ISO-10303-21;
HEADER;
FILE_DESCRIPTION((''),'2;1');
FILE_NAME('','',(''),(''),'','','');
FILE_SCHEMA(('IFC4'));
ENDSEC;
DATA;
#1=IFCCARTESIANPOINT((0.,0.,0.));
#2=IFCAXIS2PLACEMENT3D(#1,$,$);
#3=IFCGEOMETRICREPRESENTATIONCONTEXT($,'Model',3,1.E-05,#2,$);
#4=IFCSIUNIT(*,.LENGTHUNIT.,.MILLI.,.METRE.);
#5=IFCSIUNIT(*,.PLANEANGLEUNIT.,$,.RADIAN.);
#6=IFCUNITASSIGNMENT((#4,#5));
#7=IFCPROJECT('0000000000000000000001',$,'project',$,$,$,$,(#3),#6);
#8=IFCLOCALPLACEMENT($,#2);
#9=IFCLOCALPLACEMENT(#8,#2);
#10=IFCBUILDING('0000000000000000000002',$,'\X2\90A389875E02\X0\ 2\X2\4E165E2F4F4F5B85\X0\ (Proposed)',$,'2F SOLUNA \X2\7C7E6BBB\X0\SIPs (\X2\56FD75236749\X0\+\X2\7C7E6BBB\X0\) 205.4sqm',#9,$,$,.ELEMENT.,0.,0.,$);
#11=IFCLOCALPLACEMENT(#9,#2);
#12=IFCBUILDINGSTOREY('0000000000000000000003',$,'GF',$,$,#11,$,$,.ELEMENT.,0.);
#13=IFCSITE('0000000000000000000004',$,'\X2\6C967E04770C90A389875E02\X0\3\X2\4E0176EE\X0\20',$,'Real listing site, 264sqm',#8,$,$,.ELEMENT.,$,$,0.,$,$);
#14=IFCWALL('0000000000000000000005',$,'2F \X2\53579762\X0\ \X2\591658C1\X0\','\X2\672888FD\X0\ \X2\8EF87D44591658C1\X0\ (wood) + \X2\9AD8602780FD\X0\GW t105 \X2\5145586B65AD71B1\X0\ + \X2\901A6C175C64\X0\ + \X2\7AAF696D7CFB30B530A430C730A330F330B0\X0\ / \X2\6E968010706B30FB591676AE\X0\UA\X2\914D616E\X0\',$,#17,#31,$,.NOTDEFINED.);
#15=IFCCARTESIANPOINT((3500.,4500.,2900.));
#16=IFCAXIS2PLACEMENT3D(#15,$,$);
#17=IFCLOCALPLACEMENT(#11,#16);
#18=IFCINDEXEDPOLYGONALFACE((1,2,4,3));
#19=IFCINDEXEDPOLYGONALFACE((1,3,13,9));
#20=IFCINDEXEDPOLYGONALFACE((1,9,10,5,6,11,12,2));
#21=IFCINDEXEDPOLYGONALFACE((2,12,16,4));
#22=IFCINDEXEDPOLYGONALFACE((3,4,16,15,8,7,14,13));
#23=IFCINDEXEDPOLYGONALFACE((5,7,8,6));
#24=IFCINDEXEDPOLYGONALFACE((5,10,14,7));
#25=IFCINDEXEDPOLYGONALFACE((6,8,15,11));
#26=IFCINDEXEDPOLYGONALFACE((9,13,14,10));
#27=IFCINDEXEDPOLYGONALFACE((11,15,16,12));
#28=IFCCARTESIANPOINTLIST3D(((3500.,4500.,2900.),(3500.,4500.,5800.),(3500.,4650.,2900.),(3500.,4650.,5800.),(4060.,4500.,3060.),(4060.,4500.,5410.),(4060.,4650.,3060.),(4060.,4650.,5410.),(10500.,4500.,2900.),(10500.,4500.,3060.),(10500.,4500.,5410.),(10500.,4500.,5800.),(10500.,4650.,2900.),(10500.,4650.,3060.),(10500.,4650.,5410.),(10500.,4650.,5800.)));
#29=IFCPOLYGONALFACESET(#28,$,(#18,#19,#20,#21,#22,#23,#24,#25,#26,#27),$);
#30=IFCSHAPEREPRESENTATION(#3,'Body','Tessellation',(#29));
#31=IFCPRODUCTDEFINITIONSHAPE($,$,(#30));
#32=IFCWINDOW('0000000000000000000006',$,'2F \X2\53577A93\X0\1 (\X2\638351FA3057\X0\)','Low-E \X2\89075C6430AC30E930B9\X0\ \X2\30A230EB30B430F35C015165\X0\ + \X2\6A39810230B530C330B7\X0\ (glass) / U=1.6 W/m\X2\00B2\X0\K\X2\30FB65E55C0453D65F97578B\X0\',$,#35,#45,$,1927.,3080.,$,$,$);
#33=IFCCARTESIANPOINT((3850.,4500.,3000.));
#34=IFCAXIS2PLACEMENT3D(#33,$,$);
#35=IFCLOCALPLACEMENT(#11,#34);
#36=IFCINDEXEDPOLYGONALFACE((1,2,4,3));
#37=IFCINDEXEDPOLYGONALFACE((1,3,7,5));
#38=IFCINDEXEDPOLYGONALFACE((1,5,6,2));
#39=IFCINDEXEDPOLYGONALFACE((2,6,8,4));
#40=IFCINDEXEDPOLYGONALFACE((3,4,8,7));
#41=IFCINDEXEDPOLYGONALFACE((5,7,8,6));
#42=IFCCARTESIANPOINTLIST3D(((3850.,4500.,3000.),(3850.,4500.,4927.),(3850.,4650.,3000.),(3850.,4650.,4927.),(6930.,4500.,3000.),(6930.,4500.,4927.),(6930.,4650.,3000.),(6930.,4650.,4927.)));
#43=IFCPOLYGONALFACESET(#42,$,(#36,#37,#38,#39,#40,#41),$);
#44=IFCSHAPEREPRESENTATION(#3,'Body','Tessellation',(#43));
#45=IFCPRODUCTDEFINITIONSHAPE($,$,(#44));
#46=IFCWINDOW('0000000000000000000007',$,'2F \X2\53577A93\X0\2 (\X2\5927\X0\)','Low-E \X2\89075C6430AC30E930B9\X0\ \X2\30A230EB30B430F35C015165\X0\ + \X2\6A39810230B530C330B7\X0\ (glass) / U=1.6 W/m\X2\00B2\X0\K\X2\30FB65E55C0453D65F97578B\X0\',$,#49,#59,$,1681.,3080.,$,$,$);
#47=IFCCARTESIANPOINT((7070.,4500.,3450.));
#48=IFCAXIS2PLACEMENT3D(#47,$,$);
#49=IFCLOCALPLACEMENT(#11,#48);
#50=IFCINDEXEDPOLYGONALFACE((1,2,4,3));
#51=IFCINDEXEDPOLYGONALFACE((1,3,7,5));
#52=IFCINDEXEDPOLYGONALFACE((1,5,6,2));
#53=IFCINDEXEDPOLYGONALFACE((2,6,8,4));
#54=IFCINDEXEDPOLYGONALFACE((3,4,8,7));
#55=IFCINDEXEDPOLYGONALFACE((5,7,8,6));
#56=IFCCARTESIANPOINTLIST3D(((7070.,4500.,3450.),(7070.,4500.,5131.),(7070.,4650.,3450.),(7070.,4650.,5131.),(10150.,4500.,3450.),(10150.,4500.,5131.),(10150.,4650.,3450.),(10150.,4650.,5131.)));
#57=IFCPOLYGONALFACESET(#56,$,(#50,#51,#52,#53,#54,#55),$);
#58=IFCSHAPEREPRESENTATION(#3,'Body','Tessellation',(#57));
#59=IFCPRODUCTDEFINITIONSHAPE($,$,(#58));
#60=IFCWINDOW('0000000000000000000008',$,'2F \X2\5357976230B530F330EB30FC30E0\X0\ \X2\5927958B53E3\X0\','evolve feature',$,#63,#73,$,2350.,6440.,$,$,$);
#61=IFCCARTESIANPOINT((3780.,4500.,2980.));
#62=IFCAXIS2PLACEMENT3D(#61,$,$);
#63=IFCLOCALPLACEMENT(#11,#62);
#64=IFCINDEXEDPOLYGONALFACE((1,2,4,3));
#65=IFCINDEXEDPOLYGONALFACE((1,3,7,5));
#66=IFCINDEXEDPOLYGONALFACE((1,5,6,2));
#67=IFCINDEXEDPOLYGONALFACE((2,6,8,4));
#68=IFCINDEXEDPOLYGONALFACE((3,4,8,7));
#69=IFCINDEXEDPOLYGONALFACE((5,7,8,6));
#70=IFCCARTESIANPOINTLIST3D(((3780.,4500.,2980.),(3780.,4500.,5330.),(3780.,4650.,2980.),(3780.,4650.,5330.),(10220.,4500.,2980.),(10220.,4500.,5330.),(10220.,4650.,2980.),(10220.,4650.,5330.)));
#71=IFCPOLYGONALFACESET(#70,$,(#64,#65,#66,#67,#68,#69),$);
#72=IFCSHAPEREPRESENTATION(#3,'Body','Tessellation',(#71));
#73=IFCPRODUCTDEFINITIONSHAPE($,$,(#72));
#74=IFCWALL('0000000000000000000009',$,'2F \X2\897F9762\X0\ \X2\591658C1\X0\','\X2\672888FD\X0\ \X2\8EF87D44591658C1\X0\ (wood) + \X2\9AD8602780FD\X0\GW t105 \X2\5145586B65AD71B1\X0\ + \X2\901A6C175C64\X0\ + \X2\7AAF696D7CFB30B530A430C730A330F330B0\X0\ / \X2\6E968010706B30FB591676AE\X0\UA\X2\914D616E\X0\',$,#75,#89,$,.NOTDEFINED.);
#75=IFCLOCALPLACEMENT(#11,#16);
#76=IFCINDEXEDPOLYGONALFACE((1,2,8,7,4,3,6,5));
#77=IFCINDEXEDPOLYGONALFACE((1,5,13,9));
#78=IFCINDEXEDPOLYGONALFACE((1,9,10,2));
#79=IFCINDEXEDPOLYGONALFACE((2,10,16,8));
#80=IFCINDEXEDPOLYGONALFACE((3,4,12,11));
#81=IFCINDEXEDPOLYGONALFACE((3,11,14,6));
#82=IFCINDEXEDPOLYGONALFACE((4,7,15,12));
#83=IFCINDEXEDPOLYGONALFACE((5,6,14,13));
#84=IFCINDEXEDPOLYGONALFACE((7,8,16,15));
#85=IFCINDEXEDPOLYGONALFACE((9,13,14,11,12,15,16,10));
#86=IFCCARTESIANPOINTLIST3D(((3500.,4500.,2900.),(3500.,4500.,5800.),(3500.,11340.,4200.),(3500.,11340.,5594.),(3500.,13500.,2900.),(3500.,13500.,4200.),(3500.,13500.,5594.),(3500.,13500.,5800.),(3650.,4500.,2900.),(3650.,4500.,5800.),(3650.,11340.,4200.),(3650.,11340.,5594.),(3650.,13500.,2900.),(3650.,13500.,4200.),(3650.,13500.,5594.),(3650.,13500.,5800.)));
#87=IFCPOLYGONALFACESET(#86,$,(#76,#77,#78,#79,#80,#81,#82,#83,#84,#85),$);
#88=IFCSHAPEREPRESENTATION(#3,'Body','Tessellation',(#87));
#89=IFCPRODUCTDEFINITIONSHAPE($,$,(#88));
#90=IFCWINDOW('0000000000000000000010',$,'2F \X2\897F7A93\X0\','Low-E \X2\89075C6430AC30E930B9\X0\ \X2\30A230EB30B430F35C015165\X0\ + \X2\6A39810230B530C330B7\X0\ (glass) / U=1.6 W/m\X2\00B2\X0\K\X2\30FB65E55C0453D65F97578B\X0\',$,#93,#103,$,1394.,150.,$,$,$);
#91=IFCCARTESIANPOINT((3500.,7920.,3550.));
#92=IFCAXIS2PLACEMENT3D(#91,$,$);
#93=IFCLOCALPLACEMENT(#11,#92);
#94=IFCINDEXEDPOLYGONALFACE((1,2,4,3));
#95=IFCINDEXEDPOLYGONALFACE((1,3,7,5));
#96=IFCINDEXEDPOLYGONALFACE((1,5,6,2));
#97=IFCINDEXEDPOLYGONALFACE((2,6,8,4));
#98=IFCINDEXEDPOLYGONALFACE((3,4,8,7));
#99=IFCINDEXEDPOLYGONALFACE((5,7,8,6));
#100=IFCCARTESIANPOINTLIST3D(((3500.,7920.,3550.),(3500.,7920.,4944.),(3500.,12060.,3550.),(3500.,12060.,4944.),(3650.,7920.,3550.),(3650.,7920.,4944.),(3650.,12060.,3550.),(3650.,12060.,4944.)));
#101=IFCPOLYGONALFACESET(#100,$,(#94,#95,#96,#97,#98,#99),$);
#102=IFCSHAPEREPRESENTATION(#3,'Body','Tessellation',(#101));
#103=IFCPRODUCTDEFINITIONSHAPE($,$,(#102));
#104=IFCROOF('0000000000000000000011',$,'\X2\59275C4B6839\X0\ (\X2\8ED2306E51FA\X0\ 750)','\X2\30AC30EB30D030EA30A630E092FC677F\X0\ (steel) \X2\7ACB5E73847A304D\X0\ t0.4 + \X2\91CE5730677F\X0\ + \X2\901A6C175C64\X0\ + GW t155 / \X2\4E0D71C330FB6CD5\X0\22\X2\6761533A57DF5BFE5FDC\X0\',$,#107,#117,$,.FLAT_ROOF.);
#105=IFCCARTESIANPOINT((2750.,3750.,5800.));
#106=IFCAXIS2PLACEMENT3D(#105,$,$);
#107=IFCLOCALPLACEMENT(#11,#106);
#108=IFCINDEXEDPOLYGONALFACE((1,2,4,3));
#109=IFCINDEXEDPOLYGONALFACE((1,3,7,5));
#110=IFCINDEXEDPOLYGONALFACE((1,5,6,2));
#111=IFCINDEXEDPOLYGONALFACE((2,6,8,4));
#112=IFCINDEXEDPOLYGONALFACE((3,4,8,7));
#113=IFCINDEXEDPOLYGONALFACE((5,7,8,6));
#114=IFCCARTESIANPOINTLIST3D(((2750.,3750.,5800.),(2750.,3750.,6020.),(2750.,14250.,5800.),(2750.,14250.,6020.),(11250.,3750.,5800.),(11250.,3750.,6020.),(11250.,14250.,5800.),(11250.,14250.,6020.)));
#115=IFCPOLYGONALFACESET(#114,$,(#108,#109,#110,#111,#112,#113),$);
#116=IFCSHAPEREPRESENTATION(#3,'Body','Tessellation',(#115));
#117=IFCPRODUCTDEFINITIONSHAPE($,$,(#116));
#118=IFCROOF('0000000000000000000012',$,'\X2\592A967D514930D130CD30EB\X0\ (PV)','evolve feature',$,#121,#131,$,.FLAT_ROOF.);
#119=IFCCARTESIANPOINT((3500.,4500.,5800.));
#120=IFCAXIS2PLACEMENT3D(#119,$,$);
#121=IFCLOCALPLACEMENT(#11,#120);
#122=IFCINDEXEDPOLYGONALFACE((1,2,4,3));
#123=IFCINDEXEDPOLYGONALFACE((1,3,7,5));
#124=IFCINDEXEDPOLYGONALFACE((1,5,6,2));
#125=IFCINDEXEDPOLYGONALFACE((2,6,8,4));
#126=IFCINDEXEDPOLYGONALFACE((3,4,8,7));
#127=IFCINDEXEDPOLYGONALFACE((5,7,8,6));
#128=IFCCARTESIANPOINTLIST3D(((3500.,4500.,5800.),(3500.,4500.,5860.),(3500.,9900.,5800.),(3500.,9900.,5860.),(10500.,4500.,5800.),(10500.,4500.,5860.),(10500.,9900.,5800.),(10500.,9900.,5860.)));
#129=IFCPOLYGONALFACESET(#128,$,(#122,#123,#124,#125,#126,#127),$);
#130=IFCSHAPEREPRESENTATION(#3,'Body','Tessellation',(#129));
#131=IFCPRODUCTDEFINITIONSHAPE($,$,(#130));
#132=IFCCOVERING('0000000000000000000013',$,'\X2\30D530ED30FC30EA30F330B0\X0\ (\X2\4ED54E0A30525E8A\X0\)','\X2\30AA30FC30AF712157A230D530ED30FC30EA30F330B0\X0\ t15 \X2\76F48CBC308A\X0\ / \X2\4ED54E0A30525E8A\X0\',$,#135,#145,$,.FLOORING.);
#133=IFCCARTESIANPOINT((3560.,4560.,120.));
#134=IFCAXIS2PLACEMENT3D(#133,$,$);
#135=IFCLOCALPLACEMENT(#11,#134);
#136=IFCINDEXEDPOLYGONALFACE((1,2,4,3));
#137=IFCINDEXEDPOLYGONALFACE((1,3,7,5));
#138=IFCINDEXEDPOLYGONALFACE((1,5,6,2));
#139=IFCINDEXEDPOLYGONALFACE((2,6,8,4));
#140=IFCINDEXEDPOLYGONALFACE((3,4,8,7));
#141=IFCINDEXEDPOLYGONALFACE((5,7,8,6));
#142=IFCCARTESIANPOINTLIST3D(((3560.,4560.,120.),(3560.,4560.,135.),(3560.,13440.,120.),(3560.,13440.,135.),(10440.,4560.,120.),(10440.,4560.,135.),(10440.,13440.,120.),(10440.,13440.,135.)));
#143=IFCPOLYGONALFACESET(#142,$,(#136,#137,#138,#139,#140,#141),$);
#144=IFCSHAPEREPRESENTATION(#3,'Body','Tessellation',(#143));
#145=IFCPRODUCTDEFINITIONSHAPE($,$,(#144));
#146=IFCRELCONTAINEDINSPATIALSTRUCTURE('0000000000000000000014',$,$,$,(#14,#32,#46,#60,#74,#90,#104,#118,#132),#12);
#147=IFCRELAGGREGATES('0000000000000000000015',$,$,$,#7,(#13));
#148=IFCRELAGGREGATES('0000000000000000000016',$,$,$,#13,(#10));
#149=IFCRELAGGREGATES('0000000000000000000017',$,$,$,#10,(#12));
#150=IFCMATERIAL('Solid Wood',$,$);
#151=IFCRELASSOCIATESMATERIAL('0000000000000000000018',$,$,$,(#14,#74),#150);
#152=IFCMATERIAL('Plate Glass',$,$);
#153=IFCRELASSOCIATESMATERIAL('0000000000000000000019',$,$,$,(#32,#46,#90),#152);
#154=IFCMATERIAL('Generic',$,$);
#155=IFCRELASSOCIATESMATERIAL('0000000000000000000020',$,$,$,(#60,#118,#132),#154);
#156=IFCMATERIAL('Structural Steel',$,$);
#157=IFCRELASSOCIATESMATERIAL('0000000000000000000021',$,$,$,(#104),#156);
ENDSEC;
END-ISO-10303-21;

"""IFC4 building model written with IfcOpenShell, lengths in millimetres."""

from ifc_helpers import new_model, si_unit, frame, frame_2d, origin, place, context, project, spatial, rectangle, extrude, material, element, fill, save


model = new_model("IFC4")

# Units and contexts
model_context = context("Model", 3, precision=1e-05, world=origin())
ifc_project = project(units=[si_unit("LENGTHUNIT", "METRE", prefix="MILLI"), si_unit("PLANEANGLEUNIT", "RADIAN")], contexts=[model_context])

# Site, building, storey
site_placement = place(None, origin())
site = spatial("IfcSite", under=ifc_project, at=site_placement, Name="沖縄県那覇市3丁目20", ObjectType="Real listing site, 264sqm", CompositionType="ELEMENT", RefElevation=0.0)
building_placement = place(site_placement, origin())
building = spatial("IfcBuilding", under=site, at=building_placement, Name="那覇市 2世帯住宅 (Proposed)", ObjectType="2F SOLUNA 籾殻SIPs (国産杉+籾殻) 205.4sqm", CompositionType="ELEMENT", ElevationOfRefHeight=0.0, ElevationOfTerrain=0.0)
storey_placement = place(building_placement, origin())
storey = spatial("IfcBuildingStorey", under=building, at=storey_placement, Name="GF", CompositionType="ELEMENT", Elevation=0.0)

# Shared definitions
ifc_material_1 = material(Name="Solid Wood")

# Shared definitions
ifc_material_2 = material(Name="Plate Glass")
ifc_material_3 = material(Name="Generic")

# Wall, openings, windows
wall_1_placement = place(storey_placement, frame((3500.0, 4500.0, 2900.0)))
wall_1 = element("IfcWall", 1, at=wall_1_placement, inside=storey, material=ifc_material_1, Name="2F 南面 外壁", Description="木製 軸組外壁 (wood) + 高性能GW t105 充填断熱 + 通気層 + 窯業系サイディング / 準耐火・外皮UA配慮", PredefinedType="NOTDEFINED", context=model_context, shape_type="SweptSolid", body=[
    extrude(rectangle(XDim=7000.0, YDim=150.0, at=frame_2d((3500.0, 75.0))), frame((3500.0, 4500.0, 2900.0)), (0.0, 0.0, 1.0), 2900.0),
])
opening_1_placement = place(storey_placement, frame((3850.0, 4500.0, 3000.0)))
opening_1 = element("IfcOpeningElement", 2, at=opening_1_placement, cuts=wall_1, PredefinedType="NOTDEFINED", context=model_context, shape_type="SweptSolid", body=[
    extrude(rectangle(XDim=3080.0, YDim=150.0, at=frame_2d((1540.0, 75.0))), frame((3850.0, 4500.0, 3000.0)), (0.0, 0.0, 1.0), 1927.0),
])
opening_2_placement = place(storey_placement, frame((7070.0, 4500.0, 3450.0)))
opening_2 = element("IfcOpeningElement", 3, at=opening_2_placement, cuts=wall_1, PredefinedType="NOTDEFINED", context=model_context, shape_type="SweptSolid", body=[
    extrude(rectangle(XDim=3080.0, YDim=150.0, at=frame_2d((1540.0, 75.0))), frame((7070.0, 4500.0, 3450.0)), (0.0, 0.0, 1.0), 1681.0),
])
opening_3_placement = place(storey_placement, frame((3780.0, 4500.0, 2980.0)))
opening_3 = element("IfcOpeningElement", 4, at=opening_3_placement, cuts=wall_1, PredefinedType="NOTDEFINED", context=model_context, shape_type="SweptSolid", body=[
    extrude(rectangle(XDim=6440.0, YDim=150.0, at=frame_2d((3220.0, 75.0))), frame((3780.0, 4500.0, 2980.0)), (0.0, 0.0, 1.0), 2350.0),
])
window_1_placement = place(storey_placement, frame((3850.0, 4500.0, 3000.0)))
window_1 = element("IfcWindow", 5, at=window_1_placement, inside=storey, material=ifc_material_2, Name="2F 南窓1 (掃出し)", Description="Low-E 複層ガラス アルゴン封入 + 樹脂サッシ (glass) / U=1.6 W/m²K・日射取得型", OverallHeight=1927.0, OverallWidth=3080.0, context=model_context, shape_type="SweptSolid", body=[
    extrude(rectangle(XDim=3080.0, YDim=150.0, at=frame_2d((1540.0, 75.0))), frame((3850.0, 4500.0, 3000.0)), (0.0, 0.0, 1.0), 1927.0),
])
fill(opening_1, window_1)
window_2_placement = place(storey_placement, frame((7070.0, 4500.0, 3450.0)))
window_2 = element("IfcWindow", 6, at=window_2_placement, inside=storey, material=ifc_material_2, Name="2F 南窓2 (大)", Description="Low-E 複層ガラス アルゴン封入 + 樹脂サッシ (glass) / U=1.6 W/m²K・日射取得型", OverallHeight=1681.0, OverallWidth=3080.0, context=model_context, shape_type="SweptSolid", body=[
    extrude(rectangle(XDim=3080.0, YDim=150.0, at=frame_2d((1540.0, 75.0))), frame((7070.0, 4500.0, 3450.0)), (0.0, 0.0, 1.0), 1681.0),
])
fill(opening_2, window_2)
window_3_placement = place(storey_placement, frame((3780.0, 4500.0, 2980.0)))
window_3 = element("IfcWindow", 7, at=window_3_placement, inside=storey, material=ifc_material_3, Name="2F 南面サンルーム 大開口", Description="evolve feature", OverallHeight=2350.0, OverallWidth=6440.0, context=model_context, shape_type="SweptSolid", body=[
    extrude(rectangle(XDim=6440.0, YDim=150.0, at=frame_2d((3220.0, 75.0))), frame((3780.0, 4500.0, 2980.0)), (0.0, 0.0, 1.0), 2350.0),
])
fill(opening_3, window_3)

# Wall, opening, window
wall_2_placement = place(storey_placement, frame((3500.0, 4500.0, 2900.0)))
wall_2 = element("IfcWall", 8, at=wall_2_placement, inside=storey, material=ifc_material_1, Name="2F 西面 外壁", Description="木製 軸組外壁 (wood) + 高性能GW t105 充填断熱 + 通気層 + 窯業系サイディング / 準耐火・外皮UA配慮", PredefinedType="NOTDEFINED", context=model_context, shape_type="SweptSolid", body=[
    extrude(rectangle(XDim=150.0, YDim=9000.0, at=frame_2d((75.0, 4500.0))), frame((3500.0, 4500.0, 2900.0)), (0.0, 0.0, 1.0), 2900.0),
])
opening_4_placement = place(storey_placement, frame((3500.0, 7920.0, 3550.0)))
opening_4 = element("IfcOpeningElement", 9, at=opening_4_placement, cuts=wall_2, PredefinedType="NOTDEFINED", context=model_context, shape_type="SweptSolid", body=[
    extrude(rectangle(XDim=150.0, YDim=4140.0, at=frame_2d((75.0, 2070.0))), frame((3500.0, 7920.0, 3550.0)), (0.0, 0.0, 1.0), 1394.0),
])
window_4_placement = place(storey_placement, frame((3500.0, 7920.0, 3550.0)))
window_4 = element("IfcWindow", 10, at=window_4_placement, inside=storey, material=ifc_material_2, Name="2F 西窓", Description="Low-E 複層ガラス アルゴン封入 + 樹脂サッシ (glass) / U=1.6 W/m²K・日射取得型", OverallHeight=1394.0, OverallWidth=150.0, context=model_context, shape_type="SweptSolid", body=[
    extrude(rectangle(XDim=150.0, YDim=4140.0, at=frame_2d((75.0, 2070.0))), frame((3500.0, 7920.0, 3550.0)), (0.0, 0.0, 1.0), 1394.0),
])
fill(opening_4, window_4)

# Roofs
ifc_material_4 = material(Name="Structural Steel")
roof_1_placement = place(storey_placement, frame((2750.0, 3750.0, 5800.0)))
element("IfcRoof", 11, at=roof_1_placement, inside=storey, material=ifc_material_4, Name="大屋根 (軒の出 750)", Description="ガルバリウム鋼板 (steel) 立平葺き t0.4 + 野地板 + 通気層 + GW t155 / 不燃・法22条区域対応", PredefinedType="FLAT_ROOF", context=model_context, shape_type="SweptSolid", body=[
    extrude(rectangle(XDim=8500.0, YDim=10500.0, at=frame_2d((4250.0, 5250.0))), frame((2750.0, 3750.0, 5800.0)), (0.0, 0.0, 1.0), 220.0),
])
roof_2_placement = place(storey_placement, frame((3500.0, 4500.0, 5800.0)))
element("IfcRoof", 12, at=roof_2_placement, inside=storey, material=ifc_material_3, Name="太陽光パネル (PV)", Description="evolve feature", PredefinedType="FLAT_ROOF", context=model_context, shape_type="SweptSolid", body=[
    extrude(rectangle(XDim=7000.0, YDim=5400.0, at=frame_2d((3500.0, 2700.0))), frame((3500.0, 4500.0, 5800.0)), (0.0, 0.0, 1.0), 60.0),
])

# Covering
covering_placement = place(storey_placement, frame((3560.0, 4560.0, 120.0)))
element("IfcCovering", 13, at=covering_placement, inside=storey, material=ifc_material_3, Name="フローリング (仕上げ床)", Description="オーク無垢フローリング t15 直貼り / 仕上げ床", PredefinedType="FLOORING", context=model_context, shape_type="SweptSolid", body=[
    extrude(rectangle(XDim=6880.0, YDim=8880.0, at=frame_2d((3440.0, 4440.0))), frame((3560.0, 4560.0, 120.0)), (0.0, 0.0, 1.0), 15.0),
])

save(model, "model.ifc")
